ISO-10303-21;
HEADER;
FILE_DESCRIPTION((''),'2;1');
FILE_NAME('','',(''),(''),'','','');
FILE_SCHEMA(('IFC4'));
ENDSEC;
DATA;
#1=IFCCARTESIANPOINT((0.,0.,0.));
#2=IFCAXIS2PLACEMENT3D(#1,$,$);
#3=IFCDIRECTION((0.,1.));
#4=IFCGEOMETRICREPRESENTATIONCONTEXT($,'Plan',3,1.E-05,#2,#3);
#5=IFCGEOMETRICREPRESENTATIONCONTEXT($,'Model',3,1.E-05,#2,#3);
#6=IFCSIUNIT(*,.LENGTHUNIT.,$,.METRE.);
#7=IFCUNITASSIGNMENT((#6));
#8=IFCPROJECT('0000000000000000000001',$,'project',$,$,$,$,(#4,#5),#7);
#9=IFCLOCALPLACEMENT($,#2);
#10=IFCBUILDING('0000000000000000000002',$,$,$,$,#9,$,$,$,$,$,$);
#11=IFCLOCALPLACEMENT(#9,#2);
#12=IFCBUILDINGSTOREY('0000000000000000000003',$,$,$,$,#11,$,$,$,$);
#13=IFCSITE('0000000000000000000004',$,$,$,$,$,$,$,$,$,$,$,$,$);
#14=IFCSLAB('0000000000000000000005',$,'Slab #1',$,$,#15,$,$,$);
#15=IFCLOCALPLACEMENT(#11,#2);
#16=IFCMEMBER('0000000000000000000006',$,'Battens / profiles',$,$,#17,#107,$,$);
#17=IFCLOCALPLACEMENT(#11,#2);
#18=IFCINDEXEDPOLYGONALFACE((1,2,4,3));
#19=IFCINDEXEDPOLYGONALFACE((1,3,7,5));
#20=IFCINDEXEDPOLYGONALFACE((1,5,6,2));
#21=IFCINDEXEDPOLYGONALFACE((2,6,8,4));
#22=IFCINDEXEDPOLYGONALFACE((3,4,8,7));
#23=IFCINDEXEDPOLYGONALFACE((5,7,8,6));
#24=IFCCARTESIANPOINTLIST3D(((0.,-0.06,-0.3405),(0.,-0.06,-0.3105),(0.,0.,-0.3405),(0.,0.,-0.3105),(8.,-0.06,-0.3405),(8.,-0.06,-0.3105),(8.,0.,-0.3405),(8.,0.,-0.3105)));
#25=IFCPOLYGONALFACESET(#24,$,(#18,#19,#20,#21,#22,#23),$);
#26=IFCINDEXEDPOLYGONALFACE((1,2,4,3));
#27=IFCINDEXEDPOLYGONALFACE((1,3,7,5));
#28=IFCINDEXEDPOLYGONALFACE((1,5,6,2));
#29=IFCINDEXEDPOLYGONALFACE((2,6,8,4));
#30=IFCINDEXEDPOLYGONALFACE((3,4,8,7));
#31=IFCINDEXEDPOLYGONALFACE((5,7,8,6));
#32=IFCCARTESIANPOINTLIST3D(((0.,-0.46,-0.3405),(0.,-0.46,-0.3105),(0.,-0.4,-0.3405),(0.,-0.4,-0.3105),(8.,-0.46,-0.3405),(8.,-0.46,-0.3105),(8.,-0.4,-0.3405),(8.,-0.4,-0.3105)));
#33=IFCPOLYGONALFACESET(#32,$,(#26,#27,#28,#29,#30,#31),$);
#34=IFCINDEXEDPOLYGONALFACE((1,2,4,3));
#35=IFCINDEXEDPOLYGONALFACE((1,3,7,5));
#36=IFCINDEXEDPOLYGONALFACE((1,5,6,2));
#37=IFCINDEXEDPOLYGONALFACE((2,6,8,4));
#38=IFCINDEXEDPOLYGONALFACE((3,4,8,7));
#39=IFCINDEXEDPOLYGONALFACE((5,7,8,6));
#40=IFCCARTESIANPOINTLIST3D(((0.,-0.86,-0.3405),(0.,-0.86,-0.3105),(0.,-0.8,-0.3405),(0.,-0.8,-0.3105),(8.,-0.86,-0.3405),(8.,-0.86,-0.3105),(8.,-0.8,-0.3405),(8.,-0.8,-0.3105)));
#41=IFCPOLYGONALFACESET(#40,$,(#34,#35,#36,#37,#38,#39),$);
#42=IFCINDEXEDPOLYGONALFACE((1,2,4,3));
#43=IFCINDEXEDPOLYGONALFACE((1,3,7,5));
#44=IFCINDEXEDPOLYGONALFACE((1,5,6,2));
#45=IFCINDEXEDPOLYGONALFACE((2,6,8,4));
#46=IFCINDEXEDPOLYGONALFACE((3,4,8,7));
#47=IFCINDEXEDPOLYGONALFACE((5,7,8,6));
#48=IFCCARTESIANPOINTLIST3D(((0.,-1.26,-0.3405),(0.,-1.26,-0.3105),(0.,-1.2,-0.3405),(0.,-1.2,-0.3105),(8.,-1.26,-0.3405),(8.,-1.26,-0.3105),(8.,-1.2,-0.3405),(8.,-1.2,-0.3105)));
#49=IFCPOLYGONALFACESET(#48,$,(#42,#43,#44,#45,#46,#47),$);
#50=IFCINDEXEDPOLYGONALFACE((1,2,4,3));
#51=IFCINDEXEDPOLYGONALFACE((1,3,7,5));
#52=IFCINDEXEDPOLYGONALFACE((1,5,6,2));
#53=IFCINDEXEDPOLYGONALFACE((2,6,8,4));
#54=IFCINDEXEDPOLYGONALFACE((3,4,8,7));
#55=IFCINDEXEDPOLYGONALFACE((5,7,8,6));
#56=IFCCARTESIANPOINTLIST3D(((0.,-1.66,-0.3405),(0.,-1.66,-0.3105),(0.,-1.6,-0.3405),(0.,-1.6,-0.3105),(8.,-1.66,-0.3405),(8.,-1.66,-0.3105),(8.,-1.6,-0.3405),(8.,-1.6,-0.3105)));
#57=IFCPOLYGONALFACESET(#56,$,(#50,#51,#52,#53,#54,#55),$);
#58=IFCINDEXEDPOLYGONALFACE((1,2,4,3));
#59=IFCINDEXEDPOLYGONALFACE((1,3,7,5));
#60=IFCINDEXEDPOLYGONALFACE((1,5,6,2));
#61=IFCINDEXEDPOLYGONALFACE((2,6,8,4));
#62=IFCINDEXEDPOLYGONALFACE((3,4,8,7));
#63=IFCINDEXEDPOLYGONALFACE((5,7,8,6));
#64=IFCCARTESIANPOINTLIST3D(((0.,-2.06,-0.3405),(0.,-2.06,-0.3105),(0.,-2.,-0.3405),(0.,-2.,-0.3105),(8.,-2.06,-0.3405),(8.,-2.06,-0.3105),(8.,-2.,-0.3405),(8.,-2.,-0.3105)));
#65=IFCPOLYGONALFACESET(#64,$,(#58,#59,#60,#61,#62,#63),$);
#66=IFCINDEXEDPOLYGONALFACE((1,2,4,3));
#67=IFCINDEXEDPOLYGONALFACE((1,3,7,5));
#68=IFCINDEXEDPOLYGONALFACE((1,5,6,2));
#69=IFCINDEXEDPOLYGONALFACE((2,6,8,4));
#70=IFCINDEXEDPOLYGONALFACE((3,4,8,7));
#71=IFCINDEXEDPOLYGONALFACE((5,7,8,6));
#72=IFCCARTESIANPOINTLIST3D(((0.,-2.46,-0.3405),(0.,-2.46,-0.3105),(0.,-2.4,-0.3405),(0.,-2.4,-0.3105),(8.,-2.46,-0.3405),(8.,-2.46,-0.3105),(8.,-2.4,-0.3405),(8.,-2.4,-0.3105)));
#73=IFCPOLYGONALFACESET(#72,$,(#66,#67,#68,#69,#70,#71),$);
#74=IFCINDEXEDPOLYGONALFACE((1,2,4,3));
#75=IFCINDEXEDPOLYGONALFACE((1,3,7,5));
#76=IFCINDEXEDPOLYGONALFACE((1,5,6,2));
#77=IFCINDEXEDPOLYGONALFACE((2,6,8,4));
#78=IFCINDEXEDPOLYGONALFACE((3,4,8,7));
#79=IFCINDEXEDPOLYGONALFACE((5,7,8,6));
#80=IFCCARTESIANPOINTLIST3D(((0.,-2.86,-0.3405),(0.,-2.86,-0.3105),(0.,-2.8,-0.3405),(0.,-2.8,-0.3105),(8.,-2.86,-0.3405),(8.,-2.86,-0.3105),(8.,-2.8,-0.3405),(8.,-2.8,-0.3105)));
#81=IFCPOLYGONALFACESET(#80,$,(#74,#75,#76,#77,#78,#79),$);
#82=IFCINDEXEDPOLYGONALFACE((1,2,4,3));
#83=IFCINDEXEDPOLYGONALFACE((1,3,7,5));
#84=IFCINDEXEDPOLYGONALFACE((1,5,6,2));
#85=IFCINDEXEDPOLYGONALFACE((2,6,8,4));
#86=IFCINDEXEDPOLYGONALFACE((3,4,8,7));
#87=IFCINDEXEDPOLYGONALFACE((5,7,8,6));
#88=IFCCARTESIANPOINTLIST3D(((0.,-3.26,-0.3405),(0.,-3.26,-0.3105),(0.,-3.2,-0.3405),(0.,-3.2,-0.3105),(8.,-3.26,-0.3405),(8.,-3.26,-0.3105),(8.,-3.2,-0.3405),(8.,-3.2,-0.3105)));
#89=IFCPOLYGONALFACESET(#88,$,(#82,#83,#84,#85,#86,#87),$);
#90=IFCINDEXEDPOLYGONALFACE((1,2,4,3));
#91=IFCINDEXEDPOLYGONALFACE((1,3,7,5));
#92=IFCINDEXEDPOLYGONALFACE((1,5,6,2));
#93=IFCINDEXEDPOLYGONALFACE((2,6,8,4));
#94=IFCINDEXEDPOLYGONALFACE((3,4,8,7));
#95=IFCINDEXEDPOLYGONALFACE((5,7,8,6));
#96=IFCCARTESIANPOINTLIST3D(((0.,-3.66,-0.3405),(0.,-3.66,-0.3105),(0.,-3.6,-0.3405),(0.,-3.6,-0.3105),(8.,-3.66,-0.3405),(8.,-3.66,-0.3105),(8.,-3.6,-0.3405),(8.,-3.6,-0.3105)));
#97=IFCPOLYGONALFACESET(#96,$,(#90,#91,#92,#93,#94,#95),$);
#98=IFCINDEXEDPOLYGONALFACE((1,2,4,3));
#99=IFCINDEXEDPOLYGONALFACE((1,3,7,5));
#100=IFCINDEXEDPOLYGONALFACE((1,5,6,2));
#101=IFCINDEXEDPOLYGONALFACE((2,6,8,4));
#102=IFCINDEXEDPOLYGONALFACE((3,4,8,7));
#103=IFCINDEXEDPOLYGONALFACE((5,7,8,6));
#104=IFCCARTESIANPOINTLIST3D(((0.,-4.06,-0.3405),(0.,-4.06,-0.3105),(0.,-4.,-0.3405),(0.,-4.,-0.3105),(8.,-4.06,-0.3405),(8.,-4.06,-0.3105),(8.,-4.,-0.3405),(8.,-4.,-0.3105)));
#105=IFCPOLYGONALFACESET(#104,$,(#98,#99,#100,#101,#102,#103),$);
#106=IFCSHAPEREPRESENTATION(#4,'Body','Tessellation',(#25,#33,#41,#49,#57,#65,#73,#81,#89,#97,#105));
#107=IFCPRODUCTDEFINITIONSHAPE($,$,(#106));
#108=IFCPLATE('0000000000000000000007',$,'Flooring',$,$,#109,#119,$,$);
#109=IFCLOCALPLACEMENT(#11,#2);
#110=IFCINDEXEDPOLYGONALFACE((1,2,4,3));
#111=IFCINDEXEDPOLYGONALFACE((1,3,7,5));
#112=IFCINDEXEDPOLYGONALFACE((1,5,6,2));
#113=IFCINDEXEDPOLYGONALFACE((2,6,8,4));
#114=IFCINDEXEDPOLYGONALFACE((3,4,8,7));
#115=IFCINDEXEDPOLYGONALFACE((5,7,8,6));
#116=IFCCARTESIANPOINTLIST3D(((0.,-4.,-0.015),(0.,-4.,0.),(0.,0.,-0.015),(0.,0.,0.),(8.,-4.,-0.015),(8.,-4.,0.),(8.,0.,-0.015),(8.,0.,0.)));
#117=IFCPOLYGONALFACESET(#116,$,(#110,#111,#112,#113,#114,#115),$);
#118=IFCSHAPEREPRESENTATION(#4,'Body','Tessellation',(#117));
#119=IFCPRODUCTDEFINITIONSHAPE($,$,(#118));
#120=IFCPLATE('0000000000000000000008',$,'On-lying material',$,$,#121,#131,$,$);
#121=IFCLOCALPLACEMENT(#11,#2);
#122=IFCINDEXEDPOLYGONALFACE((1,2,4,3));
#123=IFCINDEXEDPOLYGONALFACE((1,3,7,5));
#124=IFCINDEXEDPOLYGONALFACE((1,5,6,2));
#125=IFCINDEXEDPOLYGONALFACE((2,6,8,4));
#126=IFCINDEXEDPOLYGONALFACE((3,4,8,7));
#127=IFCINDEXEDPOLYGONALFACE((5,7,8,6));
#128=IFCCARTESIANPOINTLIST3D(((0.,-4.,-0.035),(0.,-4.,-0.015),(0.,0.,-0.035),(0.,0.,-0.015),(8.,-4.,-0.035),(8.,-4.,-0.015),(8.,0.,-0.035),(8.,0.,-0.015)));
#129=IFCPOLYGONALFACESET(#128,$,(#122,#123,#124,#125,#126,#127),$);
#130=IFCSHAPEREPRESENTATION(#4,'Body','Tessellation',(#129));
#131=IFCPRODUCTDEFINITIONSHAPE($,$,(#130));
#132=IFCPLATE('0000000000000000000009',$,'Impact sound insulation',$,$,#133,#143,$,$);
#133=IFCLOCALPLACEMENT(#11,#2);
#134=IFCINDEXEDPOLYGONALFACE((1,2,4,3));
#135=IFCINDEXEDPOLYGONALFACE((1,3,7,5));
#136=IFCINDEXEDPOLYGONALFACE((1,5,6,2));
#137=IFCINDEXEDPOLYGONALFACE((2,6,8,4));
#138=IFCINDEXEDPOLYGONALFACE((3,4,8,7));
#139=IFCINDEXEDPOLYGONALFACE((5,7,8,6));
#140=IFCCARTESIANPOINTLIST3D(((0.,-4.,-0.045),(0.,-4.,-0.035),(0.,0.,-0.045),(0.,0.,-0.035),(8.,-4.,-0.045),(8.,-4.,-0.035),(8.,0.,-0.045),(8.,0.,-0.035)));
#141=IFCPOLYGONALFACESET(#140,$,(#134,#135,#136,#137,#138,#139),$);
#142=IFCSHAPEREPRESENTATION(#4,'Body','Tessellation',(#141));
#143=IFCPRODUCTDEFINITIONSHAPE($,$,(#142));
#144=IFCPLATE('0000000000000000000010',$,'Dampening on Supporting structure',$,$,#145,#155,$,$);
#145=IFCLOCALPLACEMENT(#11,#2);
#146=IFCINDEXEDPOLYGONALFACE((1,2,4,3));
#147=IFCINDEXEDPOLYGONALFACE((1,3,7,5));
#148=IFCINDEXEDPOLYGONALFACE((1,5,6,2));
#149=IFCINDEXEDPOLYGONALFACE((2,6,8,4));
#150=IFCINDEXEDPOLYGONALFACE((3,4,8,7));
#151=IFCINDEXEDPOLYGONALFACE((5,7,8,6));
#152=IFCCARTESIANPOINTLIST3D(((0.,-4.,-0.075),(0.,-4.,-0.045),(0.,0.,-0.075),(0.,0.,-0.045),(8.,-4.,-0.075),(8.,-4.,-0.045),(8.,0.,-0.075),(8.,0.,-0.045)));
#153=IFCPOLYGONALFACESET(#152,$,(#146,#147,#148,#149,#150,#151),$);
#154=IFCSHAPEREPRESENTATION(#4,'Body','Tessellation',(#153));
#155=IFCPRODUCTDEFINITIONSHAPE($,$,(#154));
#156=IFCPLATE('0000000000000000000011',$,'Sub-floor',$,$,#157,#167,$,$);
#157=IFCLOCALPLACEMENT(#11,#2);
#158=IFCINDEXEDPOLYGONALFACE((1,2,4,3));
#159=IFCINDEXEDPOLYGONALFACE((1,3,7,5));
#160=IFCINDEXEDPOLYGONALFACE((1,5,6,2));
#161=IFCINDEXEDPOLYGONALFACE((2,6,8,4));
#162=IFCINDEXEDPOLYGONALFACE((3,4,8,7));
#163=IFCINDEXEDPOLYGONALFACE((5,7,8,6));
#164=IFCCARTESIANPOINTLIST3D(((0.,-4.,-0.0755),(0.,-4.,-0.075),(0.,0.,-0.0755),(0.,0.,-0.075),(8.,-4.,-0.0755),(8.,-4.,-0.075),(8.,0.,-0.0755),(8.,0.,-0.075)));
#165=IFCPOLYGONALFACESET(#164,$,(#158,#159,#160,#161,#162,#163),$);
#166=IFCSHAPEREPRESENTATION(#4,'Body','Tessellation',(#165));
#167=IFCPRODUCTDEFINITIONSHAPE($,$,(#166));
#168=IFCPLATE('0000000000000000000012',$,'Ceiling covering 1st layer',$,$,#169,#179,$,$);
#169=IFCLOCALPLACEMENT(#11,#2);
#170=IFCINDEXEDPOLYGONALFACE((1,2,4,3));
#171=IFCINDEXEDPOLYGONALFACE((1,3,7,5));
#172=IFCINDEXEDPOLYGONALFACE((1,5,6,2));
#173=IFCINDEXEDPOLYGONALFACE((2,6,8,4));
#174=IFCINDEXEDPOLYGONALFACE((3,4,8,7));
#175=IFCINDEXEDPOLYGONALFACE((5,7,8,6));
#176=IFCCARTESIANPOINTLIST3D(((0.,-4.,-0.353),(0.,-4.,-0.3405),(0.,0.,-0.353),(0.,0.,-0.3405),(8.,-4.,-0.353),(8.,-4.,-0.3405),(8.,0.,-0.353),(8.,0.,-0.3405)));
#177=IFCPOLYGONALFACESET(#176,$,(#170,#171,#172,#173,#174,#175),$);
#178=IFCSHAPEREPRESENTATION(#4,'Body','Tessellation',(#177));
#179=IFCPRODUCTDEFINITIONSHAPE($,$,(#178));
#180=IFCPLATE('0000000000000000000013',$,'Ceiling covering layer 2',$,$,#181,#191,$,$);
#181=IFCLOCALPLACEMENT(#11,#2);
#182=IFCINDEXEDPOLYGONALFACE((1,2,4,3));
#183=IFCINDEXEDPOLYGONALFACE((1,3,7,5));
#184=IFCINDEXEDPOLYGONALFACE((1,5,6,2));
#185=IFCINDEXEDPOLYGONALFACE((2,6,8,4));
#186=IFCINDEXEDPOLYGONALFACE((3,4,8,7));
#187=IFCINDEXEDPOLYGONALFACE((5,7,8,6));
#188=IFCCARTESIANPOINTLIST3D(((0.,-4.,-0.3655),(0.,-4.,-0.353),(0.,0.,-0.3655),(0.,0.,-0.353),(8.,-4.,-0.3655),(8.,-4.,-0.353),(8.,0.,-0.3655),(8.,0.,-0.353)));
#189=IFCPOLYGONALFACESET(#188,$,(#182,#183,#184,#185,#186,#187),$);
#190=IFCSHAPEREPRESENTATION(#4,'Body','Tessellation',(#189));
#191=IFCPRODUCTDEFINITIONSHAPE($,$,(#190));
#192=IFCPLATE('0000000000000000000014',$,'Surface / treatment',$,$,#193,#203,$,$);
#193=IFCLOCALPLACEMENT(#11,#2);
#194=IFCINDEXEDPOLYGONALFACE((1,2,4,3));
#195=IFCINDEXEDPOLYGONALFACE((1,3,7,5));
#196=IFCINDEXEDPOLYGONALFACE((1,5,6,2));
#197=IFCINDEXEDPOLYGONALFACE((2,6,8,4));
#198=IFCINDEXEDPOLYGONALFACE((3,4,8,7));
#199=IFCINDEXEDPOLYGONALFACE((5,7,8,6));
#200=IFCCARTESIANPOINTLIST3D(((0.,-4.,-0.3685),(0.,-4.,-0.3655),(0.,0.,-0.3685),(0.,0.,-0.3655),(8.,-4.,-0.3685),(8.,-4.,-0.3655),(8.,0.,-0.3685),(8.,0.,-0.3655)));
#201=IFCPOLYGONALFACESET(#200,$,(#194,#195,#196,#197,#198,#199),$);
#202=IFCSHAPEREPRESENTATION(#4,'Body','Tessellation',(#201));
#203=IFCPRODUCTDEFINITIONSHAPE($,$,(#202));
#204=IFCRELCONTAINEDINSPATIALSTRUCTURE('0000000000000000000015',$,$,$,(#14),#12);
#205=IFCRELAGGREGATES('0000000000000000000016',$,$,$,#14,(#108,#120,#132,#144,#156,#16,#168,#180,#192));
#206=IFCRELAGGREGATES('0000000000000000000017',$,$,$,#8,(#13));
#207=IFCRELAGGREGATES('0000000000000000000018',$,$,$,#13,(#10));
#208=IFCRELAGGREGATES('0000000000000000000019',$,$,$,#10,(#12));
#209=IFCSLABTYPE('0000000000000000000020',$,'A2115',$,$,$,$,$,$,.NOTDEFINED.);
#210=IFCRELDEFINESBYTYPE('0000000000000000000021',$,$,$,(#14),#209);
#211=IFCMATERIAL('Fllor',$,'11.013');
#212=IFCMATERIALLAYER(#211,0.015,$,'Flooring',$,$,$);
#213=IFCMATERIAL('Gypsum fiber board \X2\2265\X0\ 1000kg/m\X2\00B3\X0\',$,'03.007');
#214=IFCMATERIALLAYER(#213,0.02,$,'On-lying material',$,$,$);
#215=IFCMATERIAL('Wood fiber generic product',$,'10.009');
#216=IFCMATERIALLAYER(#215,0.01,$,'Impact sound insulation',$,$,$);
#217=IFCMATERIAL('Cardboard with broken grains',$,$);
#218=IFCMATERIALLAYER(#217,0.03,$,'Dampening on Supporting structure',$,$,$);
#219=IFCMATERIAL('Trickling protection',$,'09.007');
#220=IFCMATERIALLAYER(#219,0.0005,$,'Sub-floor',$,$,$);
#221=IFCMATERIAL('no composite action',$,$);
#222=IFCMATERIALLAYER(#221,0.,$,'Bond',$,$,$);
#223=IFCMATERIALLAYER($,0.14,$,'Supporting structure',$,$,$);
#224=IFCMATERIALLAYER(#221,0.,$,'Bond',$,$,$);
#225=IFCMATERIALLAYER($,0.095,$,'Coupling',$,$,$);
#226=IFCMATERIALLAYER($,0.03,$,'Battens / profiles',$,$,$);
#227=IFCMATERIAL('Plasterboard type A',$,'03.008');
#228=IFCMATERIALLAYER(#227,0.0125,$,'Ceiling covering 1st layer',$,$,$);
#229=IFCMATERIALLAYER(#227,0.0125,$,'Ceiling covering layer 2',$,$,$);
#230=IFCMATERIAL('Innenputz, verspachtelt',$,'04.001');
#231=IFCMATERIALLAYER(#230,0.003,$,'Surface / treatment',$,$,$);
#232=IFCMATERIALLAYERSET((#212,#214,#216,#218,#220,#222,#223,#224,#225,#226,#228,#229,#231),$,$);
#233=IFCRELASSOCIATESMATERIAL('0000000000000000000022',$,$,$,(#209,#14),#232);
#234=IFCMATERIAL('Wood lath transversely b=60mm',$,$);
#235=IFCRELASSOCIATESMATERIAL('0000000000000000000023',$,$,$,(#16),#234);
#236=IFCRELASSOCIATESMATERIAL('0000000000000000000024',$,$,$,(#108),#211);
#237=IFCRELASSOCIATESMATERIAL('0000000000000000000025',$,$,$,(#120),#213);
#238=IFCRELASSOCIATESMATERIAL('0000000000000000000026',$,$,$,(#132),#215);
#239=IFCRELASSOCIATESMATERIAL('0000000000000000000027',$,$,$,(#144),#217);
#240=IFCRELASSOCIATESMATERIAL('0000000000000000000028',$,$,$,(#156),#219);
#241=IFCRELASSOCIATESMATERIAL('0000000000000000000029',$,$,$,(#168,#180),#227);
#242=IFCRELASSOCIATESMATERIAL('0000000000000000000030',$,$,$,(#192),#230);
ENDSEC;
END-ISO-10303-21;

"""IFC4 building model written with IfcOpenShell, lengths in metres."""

from ifc_helpers import new_model, si_unit, direction, frame, frame_2d, origin, origin_with_axes, place, context, project, spatial, rectangle, extrude, material, layer, layer_set, type_object, element, aggregate, save


model = new_model("IFC4")

# Units and contexts
plan_context = context("Plan", 3, precision=1e-05, world=origin(), true_north=direction((0.0, 1.0)))
model_context = context("Model", 3, precision=1e-05, world=origin(), true_north=direction((0.0, 1.0)))
ifc_project = project(units=[si_unit("LENGTHUNIT", "METRE")], contexts=[plan_context, model_context])

# Site, building, storey
site = spatial("IfcSite", under=ifc_project)
building_placement = place(None, origin())
building = spatial("IfcBuilding", under=site, at=building_placement)
storey_placement = place(building_placement, origin())
storey = spatial("IfcBuildingStorey", under=building, at=storey_placement)

# Slab, member, plates
ifc_material_1 = material(Name="Fllor", Category="11.013")
ifc_layer_1 = layer(ifc_material_1, 0.015, Name="Flooring")
ifc_material_2 = material(Name="Gypsum fiber board ≥ 1000kg/m³", Category="03.007")
ifc_layer_2 = layer(ifc_material_2, 0.02, Name="On-lying material")
ifc_material_3 = material(Name="Wood fiber generic product", Category="10.009")
ifc_layer_3 = layer(ifc_material_3, 0.01, Name="Impact sound insulation")
ifc_material_4 = material(Name="Cardboard with broken grains")
ifc_layer_4 = layer(ifc_material_4, 0.03, Name="Dampening on Supporting structure")
ifc_material_5 = material(Name="Trickling protection", Category="09.007")
ifc_layer_5 = layer(ifc_material_5, 0.0005, Name="Sub-floor")
ifc_material_6 = material(Name="no composite action")
ifc_layer_6 = layer(ifc_material_6, 0.0, Name="Bond")
ifc_layer_7 = layer(None, 0.14, Name="Supporting structure")
ifc_layer_8 = layer(ifc_material_6, 0.0, Name="Bond")
ifc_layer_9 = layer(None, 0.095, Name="Coupling")
ifc_layer_10 = layer(None, 0.03, Name="Battens / profiles")
ifc_material_7 = material(Name="Plasterboard type A", Category="03.008")
ifc_layer_11 = layer(ifc_material_7, 0.0125, Name="Ceiling covering 1st layer")
ifc_layer_12 = layer(ifc_material_7, 0.0125, Name="Ceiling covering layer 2")
ifc_material_8 = material(Name="Innenputz, verspachtelt", Category="04.001")
ifc_layer_13 = layer(ifc_material_8, 0.003, Name="Surface / treatment")
ifc_layer_set = layer_set([ifc_layer_1, ifc_layer_2, ifc_layer_3, ifc_layer_4, ifc_layer_5, ifc_layer_6, ifc_layer_7, ifc_layer_8, ifc_layer_9, ifc_layer_10, ifc_layer_11, ifc_layer_12, ifc_layer_13])
slab_type = type_object("IfcSlabType", Name="A2115", PredefinedType="NOTDEFINED", material=ifc_layer_set)
slab_placement = place(None, frame((0.0, 0.0, 0.0), z_axis=(0.0, 0.0, -1.0), x_axis=(1.0, 0.0, 0.0)))
slab = element("IfcSlab", 1, at=slab_placement, inside=storey, type_object=slab_type, material=ifc_layer_set, Name="Slab #1")
ifc_material_9 = material(Name="Wood lath transversely b=60mm")
member_1_placement = place(slab_placement, origin())
member_1 = element("IfcMember", 2, at=member_1_placement, material=ifc_material_9, Name="Battens / profiles", context=plan_context, shape_type="SweptSolid", body=[
    extrude(rectangle(XDim=0.06, YDim=0.03, at=frame_2d((0.03, 0.015), x_axis=(1.0, 0.0))), frame((0.0, 0.0, 0.3105), z_axis=(1.0, 0.0, 0.0), x_axis=(0.0, 1.0, 0.0)), (0.0, 0.0, 1.0), 8.0),
    extrude(rectangle(XDim=0.06, YDim=0.03, at=frame_2d((0.03, 0.015), x_axis=(1.0, 0.0))), frame((0.0, 0.4, 0.3105), z_axis=(1.0, 0.0, 0.0), x_axis=(0.0, 1.0, 0.0)), (0.0, 0.0, 1.0), 8.0),
    extrude(rectangle(XDim=0.06, YDim=0.03, at=frame_2d((0.03, 0.015), x_axis=(1.0, 0.0))), frame((0.0, 0.8, 0.3105), z_axis=(1.0, 0.0, 0.0), x_axis=(0.0, 1.0, 0.0)), (0.0, 0.0, 1.0), 8.0),
    extrude(rectangle(XDim=0.06, YDim=0.03, at=frame_2d((0.03, 0.015), x_axis=(1.0, 0.0))), frame((0.0, 1.2, 0.3105), z_axis=(1.0, 0.0, 0.0), x_axis=(0.0, 1.0, 0.0)), (0.0, 0.0, 1.0), 8.0),
    extrude(rectangle(XDim=0.06, YDim=0.03, at=frame_2d((0.03, 0.015), x_axis=(1.0, 0.0))), frame((0.0, 1.6, 0.3105), z_axis=(1.0, 0.0, 0.0), x_axis=(0.0, 1.0, 0.0)), (0.0, 0.0, 1.0), 8.0),
    extrude(rectangle(XDim=0.06, YDim=0.03, at=frame_2d((0.03, 0.015), x_axis=(1.0, 0.0))), frame((0.0, 2.0, 0.3105), z_axis=(1.0, 0.0, 0.0), x_axis=(0.0, 1.0, 0.0)), (0.0, 0.0, 1.0), 8.0),
    extrude(rectangle(XDim=0.06, YDim=0.03, at=frame_2d((0.03, 0.015), x_axis=(1.0, 0.0))), frame((0.0, 2.4, 0.3105), z_axis=(1.0, 0.0, 0.0), x_axis=(0.0, 1.0, 0.0)), (0.0, 0.0, 1.0), 8.0),
    extrude(rectangle(XDim=0.06, YDim=0.03, at=frame_2d((0.03, 0.015), x_axis=(1.0, 0.0))), frame((0.0, 2.8, 0.3105), z_axis=(1.0, 0.0, 0.0), x_axis=(0.0, 1.0, 0.0)), (0.0, 0.0, 1.0), 8.0),
    extrude(rectangle(XDim=0.06, YDim=0.03, at=frame_2d((0.03, 0.015), x_axis=(1.0, 0.0))), frame((0.0, 3.2, 0.3105), z_axis=(1.0, 0.0, 0.0), x_axis=(0.0, 1.0, 0.0)), (0.0, 0.0, 1.0), 8.0),
    extrude(rectangle(XDim=0.06, YDim=0.03, at=frame_2d((0.03, 0.015), x_axis=(1.0, 0.0))), frame((0.0, 3.6, 0.3105), z_axis=(1.0, 0.0, 0.0), x_axis=(0.0, 1.0, 0.0)), (0.0, 0.0, 1.0), 8.0),
    extrude(rectangle(XDim=0.06, YDim=0.03, at=frame_2d((0.03, 0.015), x_axis=(1.0, 0.0))), frame((0.0, 4.0, 0.3105), z_axis=(1.0, 0.0, 0.0), x_axis=(0.0, 1.0, 0.0)), (0.0, 0.0, 1.0), 8.0),
])
plate_1_placement = place(slab_placement, origin())
plate_1 = element("IfcPlate", 3, at=plate_1_placement, material=ifc_material_1, Name="Flooring", context=plan_context, shape_type="SweptSolid", body=[
    extrude(rectangle(XDim=8.0, YDim=4.0, at=frame_2d((4.0, 2.0), x_axis=(1.0, 0.0))), origin_with_axes(), (0.0, 0.0, 1.0), 0.015),
])
plate_2_placement = place(slab_placement, origin())
plate_2 = element("IfcPlate", 4, at=plate_2_placement, material=ifc_material_2, Name="On-lying material", context=plan_context, shape_type="SweptSolid", body=[
    extrude(rectangle(XDim=8.0, YDim=4.0, at=frame_2d((4.0, 2.0), x_axis=(1.0, 0.0))), frame((0.0, 0.0, 0.015), z_axis=(0.0, 0.0, 1.0), x_axis=(1.0, 0.0, 0.0)), (0.0, 0.0, 1.0), 0.02),
])
plate_3_placement = place(slab_placement, origin())
plate_3 = element("IfcPlate", 5, at=plate_3_placement, material=ifc_material_3, Name="Impact sound insulation", context=plan_context, shape_type="SweptSolid", body=[
    extrude(rectangle(XDim=8.0, YDim=4.0, at=frame_2d((4.0, 2.0), x_axis=(1.0, 0.0))), frame((0.0, 0.0, 0.035), z_axis=(0.0, 0.0, 1.0), x_axis=(1.0, 0.0, 0.0)), (0.0, 0.0, 1.0), 0.01),
])
plate_4_placement = place(slab_placement, origin())
plate_4 = element("IfcPlate", 6, at=plate_4_placement, material=ifc_material_4, Name="Dampening on Supporting structure", context=plan_context, shape_type="SweptSolid", body=[
    extrude(rectangle(XDim=8.0, YDim=4.0, at=frame_2d((4.0, 2.0), x_axis=(1.0, 0.0))), frame((0.0, 0.0, 0.045), z_axis=(0.0, 0.0, 1.0), x_axis=(1.0, 0.0, 0.0)), (0.0, 0.0, 1.0), 0.03),
])
plate_5_placement = place(slab_placement, origin())
plate_5 = element("IfcPlate", 7, at=plate_5_placement, material=ifc_material_5, Name="Sub-floor", context=plan_context, shape_type="SweptSolid", body=[
    extrude(rectangle(XDim=8.0, YDim=4.0, at=frame_2d((4.0, 2.0), x_axis=(1.0, 0.0))), frame((0.0, 0.0, 0.075), z_axis=(0.0, 0.0, 1.0), x_axis=(1.0, 0.0, 0.0)), (0.0, 0.0, 1.0), 0.0005),
])
plate_6_placement = place(slab_placement, origin())
plate_6 = element("IfcPlate", 8, at=plate_6_placement, material=ifc_material_7, Name="Ceiling covering 1st layer", context=plan_context, shape_type="SweptSolid", body=[
    extrude(rectangle(XDim=8.0, YDim=4.0, at=frame_2d((4.0, 2.0), x_axis=(1.0, 0.0))), frame((0.0, 0.0, 0.3405), z_axis=(0.0, 0.0, 1.0), x_axis=(1.0, 0.0, 0.0)), (0.0, 0.0, 1.0), 0.0125),
])
plate_7_placement = place(slab_placement, origin())
plate_7 = element("IfcPlate", 9, at=plate_7_placement, material=ifc_material_7, Name="Ceiling covering layer 2", context=plan_context, shape_type="SweptSolid", body=[
    extrude(rectangle(XDim=8.0, YDim=4.0, at=frame_2d((4.0, 2.0), x_axis=(1.0, 0.0))), frame((0.0, 0.0, 0.353), z_axis=(0.0, 0.0, 1.0), x_axis=(1.0, 0.0, 0.0)), (0.0, 0.0, 1.0), 0.0125),
])
plate_8_placement = place(slab_placement, origin())
plate_8 = element("IfcPlate", 10, at=plate_8_placement, material=ifc_material_8, Name="Surface / treatment", context=plan_context, shape_type="SweptSolid", body=[
    extrude(rectangle(XDim=8.0, YDim=4.0, at=frame_2d((4.0, 2.0), x_axis=(1.0, 0.0))), frame((0.0, 0.0, 0.3655), z_axis=(0.0, 0.0, 1.0), x_axis=(1.0, 0.0, 0.0)), (0.0, 0.0, 1.0), 0.003),
])
aggregate(slab, [plate_1, plate_2, plate_3, plate_4, plate_5, member_1, plate_6, plate_7, plate_8])

save(model, "model.ifc")
